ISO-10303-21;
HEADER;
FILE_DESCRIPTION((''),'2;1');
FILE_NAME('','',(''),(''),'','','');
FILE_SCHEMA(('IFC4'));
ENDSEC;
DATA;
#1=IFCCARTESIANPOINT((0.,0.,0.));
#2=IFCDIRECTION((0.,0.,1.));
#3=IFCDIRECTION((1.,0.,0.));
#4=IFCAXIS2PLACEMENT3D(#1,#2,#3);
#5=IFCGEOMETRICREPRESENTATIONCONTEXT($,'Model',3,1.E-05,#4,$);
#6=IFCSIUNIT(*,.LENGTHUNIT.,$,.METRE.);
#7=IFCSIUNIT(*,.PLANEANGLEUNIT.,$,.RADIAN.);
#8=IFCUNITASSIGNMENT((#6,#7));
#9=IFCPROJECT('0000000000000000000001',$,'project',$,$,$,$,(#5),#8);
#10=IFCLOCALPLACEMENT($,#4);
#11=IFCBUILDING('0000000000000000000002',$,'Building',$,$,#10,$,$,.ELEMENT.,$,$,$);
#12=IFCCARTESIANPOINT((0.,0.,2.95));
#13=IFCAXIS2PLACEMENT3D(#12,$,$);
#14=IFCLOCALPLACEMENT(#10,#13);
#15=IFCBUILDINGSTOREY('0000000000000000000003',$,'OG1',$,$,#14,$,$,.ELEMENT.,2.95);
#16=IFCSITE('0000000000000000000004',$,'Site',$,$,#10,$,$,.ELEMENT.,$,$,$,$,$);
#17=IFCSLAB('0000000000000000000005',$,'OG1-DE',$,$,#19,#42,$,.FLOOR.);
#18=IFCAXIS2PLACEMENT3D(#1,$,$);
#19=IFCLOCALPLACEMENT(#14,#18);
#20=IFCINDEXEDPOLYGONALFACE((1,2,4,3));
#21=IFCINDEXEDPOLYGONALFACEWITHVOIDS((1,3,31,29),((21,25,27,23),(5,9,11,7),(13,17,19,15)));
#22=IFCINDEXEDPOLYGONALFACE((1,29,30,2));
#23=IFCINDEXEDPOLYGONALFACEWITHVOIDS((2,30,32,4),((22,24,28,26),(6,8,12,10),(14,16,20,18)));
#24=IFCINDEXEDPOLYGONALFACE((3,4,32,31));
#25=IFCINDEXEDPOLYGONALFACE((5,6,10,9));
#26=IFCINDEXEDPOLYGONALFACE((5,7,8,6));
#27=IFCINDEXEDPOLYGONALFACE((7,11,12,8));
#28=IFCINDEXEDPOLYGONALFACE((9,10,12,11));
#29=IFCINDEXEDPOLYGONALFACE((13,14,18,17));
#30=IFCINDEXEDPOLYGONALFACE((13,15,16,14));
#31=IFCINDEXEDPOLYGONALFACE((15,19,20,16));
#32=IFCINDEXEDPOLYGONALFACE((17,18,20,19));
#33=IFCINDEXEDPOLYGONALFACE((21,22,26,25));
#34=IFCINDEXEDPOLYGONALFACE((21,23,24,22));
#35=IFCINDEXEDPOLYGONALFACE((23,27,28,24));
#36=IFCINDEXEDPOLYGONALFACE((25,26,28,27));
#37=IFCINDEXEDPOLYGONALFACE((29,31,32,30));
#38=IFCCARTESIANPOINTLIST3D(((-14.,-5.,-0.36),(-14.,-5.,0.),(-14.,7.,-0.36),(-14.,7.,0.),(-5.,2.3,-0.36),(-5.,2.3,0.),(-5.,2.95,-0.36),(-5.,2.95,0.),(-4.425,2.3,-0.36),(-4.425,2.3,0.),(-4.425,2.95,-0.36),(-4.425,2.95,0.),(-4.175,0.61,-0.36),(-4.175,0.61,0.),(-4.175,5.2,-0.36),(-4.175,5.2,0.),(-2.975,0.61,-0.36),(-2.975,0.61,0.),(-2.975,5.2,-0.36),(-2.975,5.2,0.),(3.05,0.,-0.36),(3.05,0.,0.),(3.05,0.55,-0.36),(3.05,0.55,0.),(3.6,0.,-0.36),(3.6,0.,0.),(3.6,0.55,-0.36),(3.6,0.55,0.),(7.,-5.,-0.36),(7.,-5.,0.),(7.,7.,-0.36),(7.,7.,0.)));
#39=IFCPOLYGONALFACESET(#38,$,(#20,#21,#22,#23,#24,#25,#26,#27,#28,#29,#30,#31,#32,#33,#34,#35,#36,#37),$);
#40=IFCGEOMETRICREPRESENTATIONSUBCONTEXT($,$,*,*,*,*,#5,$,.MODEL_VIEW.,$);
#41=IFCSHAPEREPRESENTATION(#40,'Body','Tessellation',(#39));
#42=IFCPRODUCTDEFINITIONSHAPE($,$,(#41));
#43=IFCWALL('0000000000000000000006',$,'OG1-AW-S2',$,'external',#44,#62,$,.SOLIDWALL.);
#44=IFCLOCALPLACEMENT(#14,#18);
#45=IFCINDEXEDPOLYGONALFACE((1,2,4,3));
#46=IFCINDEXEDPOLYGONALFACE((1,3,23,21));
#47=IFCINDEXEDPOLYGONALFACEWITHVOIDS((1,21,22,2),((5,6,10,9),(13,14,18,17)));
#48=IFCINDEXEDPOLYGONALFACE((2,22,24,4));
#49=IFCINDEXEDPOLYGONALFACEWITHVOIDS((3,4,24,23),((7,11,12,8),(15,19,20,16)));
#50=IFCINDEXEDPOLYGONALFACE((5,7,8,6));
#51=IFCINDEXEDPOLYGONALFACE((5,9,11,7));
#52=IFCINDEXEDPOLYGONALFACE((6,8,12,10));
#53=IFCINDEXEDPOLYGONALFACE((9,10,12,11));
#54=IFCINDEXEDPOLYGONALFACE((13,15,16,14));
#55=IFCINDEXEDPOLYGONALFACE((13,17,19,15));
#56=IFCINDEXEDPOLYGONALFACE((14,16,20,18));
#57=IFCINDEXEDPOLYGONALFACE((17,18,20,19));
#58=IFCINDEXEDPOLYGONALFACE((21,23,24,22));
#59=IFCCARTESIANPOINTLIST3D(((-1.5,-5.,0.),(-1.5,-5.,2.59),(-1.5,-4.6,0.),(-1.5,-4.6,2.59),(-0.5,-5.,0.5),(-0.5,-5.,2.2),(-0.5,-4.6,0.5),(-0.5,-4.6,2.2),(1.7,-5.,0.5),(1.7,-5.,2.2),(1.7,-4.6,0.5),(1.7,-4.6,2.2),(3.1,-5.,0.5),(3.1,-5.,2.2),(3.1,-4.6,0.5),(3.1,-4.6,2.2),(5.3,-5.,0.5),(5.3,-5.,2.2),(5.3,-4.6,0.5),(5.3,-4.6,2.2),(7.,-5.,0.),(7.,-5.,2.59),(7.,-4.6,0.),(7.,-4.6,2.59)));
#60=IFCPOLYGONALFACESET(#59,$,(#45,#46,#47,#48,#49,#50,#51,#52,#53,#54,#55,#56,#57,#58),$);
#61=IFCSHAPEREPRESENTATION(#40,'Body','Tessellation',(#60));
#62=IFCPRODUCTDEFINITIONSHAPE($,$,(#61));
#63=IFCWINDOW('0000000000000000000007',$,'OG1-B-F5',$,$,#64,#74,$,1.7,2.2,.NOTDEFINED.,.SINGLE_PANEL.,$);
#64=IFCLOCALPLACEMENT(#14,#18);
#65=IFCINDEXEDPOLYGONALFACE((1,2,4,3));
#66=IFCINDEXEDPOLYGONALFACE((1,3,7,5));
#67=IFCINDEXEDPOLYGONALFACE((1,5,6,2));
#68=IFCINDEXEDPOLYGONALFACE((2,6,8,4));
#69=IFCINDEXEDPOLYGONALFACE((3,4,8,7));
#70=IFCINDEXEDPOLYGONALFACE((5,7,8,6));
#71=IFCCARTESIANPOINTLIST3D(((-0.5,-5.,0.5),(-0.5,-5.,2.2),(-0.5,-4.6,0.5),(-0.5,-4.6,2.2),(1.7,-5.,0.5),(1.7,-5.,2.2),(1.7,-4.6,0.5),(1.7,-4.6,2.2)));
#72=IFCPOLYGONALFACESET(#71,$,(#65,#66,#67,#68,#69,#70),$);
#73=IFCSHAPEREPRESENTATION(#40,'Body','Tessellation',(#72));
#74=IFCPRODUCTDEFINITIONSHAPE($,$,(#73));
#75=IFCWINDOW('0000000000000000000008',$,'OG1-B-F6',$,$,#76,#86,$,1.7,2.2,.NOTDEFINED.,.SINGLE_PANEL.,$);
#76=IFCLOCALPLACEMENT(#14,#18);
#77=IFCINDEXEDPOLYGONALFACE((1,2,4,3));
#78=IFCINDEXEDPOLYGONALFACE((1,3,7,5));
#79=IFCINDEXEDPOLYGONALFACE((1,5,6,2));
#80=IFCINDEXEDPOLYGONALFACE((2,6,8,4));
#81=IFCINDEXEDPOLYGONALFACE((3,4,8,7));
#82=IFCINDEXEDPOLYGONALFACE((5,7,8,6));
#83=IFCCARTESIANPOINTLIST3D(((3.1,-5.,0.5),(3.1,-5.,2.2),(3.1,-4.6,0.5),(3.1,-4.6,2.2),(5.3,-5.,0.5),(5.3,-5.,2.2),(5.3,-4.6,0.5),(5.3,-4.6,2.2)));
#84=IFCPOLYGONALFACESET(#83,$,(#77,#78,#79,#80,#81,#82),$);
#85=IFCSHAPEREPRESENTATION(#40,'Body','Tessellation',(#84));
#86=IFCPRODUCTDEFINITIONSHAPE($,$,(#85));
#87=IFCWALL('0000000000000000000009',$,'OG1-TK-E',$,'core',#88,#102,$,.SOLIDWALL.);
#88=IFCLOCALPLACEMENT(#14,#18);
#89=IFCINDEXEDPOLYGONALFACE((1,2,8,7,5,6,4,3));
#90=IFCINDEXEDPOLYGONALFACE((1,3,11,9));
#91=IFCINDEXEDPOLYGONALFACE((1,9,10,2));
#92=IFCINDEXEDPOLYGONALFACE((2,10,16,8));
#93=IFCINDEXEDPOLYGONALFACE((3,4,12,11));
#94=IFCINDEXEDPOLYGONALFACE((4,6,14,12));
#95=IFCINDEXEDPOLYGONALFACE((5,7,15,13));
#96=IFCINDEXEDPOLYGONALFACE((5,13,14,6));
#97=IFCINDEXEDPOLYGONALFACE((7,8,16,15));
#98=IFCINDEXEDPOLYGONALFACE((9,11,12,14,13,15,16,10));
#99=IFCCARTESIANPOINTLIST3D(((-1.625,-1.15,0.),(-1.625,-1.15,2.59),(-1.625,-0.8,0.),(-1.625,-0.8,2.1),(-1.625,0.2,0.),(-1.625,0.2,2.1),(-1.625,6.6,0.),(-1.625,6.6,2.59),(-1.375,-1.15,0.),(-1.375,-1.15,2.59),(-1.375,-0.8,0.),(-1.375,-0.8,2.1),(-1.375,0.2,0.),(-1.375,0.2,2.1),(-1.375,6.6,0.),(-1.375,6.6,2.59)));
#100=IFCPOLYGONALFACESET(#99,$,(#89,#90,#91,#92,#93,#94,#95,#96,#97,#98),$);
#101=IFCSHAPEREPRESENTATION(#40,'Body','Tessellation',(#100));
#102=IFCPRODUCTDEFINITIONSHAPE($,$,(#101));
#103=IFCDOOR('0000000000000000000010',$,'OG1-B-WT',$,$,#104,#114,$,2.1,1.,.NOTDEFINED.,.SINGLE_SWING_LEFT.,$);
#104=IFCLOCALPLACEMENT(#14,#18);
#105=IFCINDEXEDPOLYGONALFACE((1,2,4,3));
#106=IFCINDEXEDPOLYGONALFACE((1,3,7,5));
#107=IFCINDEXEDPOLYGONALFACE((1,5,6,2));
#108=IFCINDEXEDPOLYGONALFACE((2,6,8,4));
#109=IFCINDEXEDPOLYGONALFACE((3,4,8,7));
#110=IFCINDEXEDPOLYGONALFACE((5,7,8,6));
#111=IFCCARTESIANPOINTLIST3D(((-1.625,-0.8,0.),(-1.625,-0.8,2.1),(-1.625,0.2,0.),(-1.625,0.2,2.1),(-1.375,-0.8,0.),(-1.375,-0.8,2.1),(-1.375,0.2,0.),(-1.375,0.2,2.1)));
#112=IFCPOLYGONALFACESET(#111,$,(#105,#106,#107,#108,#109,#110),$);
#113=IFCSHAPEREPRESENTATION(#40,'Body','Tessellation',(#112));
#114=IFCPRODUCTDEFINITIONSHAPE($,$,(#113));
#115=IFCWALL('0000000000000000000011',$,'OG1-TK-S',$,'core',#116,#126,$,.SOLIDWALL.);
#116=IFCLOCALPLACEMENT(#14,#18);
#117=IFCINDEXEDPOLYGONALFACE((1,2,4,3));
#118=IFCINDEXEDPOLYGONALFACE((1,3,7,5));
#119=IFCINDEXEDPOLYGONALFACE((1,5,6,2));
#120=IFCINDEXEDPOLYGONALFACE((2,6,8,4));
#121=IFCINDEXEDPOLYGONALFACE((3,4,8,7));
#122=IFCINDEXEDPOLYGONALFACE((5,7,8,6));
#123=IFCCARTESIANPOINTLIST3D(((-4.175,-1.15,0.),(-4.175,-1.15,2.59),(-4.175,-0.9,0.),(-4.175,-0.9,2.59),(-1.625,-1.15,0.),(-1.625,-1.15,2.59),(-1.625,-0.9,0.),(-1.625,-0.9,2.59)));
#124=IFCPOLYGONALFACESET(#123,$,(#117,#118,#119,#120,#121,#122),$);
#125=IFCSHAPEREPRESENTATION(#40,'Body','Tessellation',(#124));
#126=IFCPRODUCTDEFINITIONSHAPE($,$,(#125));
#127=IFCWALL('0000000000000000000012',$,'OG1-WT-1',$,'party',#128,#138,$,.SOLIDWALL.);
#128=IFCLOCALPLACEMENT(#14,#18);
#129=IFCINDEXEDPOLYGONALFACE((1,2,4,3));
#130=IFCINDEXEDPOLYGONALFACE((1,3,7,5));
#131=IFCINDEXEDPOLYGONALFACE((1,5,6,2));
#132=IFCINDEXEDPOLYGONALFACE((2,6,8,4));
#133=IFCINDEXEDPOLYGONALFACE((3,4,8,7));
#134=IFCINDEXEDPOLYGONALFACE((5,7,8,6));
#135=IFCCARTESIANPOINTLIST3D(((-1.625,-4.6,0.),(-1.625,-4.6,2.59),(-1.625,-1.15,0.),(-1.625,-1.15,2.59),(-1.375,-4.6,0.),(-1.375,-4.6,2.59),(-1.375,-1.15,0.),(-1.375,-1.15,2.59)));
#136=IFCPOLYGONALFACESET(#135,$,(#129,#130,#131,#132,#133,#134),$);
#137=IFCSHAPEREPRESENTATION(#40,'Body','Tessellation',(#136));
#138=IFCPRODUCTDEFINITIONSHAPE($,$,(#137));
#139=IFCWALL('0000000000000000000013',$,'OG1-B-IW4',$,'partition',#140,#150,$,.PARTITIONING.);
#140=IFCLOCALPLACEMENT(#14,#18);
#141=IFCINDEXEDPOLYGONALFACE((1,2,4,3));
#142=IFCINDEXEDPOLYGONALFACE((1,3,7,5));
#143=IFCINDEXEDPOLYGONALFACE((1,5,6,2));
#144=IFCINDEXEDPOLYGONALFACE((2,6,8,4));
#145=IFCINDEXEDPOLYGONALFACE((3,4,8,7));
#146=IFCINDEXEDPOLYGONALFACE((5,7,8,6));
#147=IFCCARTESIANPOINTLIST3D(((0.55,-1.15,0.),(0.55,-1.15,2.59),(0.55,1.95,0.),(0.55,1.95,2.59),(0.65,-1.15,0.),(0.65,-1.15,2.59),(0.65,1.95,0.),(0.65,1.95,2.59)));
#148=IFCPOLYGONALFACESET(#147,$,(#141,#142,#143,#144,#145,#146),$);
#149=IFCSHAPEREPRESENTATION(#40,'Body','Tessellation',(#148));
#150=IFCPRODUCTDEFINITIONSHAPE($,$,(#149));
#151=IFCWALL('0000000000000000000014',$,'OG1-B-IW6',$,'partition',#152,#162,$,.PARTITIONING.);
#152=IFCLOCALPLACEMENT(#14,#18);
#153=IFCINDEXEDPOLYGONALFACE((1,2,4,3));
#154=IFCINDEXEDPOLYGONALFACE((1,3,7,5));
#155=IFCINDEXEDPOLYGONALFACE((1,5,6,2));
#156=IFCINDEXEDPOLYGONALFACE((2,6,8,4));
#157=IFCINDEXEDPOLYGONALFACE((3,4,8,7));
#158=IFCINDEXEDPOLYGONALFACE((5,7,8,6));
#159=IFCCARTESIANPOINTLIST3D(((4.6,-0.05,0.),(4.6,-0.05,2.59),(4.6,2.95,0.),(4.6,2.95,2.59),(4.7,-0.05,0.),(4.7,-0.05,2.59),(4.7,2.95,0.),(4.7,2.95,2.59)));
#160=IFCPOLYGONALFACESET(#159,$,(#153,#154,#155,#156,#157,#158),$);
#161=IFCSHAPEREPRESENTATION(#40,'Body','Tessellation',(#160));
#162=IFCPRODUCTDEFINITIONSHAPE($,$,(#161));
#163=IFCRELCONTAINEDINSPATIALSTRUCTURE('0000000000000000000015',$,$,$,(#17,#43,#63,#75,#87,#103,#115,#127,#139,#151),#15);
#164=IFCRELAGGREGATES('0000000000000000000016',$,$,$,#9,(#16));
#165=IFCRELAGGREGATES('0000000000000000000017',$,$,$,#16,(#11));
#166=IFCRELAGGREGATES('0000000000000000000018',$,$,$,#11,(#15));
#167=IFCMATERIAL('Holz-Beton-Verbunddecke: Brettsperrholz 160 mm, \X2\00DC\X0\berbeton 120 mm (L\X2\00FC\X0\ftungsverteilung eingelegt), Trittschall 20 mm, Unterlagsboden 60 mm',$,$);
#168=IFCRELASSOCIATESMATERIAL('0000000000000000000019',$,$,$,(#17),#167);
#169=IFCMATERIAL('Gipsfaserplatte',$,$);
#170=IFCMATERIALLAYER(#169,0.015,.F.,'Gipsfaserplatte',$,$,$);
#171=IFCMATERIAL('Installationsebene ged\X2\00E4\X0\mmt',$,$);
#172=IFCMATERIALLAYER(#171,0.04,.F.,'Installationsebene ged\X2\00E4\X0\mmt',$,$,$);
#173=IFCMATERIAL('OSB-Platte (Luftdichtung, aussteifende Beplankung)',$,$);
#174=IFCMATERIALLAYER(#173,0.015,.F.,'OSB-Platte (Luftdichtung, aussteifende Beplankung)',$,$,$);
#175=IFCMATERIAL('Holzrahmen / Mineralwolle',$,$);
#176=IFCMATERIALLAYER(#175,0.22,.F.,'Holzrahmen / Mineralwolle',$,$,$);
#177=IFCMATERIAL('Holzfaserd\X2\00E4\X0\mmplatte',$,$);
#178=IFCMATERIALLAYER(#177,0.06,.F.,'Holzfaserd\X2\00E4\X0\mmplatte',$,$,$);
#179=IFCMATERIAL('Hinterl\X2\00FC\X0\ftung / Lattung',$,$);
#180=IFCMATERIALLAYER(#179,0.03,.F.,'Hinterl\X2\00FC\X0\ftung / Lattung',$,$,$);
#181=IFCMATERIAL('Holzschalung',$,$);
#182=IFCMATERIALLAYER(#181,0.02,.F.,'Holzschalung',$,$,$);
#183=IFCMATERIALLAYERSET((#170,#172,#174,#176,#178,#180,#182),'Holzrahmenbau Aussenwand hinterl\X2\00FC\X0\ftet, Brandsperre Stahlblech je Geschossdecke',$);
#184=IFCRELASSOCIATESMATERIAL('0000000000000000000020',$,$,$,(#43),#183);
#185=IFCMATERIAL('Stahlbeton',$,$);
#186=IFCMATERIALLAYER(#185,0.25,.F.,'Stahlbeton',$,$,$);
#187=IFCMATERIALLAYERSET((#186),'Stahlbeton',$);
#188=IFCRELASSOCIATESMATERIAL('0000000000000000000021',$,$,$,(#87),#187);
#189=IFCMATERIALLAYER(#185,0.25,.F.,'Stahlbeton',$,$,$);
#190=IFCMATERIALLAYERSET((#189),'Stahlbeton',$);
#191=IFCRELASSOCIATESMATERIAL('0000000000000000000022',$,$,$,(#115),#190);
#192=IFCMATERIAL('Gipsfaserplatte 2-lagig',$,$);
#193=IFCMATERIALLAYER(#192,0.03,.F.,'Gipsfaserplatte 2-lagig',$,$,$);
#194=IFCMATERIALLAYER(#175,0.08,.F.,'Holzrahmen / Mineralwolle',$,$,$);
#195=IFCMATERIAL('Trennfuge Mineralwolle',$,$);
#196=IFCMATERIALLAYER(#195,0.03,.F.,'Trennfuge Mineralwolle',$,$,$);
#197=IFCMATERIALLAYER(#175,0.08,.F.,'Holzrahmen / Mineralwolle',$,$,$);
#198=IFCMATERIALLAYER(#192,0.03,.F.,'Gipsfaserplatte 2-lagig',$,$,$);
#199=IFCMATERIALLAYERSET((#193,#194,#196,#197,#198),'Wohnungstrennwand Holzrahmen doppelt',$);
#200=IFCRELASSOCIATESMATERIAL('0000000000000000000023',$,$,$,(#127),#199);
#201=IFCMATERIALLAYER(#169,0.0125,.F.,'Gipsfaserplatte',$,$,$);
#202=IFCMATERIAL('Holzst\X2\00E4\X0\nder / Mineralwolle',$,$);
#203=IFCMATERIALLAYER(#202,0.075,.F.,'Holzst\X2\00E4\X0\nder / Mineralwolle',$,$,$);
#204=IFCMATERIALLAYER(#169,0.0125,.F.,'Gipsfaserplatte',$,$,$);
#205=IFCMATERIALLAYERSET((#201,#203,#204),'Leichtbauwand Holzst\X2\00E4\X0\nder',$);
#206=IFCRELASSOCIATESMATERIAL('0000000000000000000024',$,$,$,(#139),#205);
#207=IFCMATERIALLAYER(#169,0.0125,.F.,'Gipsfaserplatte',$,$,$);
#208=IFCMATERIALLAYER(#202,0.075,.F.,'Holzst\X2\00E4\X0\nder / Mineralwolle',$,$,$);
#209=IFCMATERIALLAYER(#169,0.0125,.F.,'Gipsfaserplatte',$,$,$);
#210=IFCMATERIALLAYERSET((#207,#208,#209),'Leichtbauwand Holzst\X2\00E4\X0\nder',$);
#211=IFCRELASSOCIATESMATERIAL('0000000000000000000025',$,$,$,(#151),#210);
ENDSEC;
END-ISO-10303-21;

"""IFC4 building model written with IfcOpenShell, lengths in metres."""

from ifc_helpers import new_model, si_unit, frame, frame_2d, origin, origin_with_axes, origin_2d, place, context, subcontext, project, spatial, polyline, rectangle, outline, extrude, material, layer, layer_set, element, fill, save


model = new_model("IFC4")

# Units and contexts
model_context = context("Model", 3, precision=1e-05, world=origin_with_axes())
sub_context = subcontext(model_context, None, None, "MODEL_VIEW")
ifc_project = project(units=[si_unit("LENGTHUNIT", "METRE"), si_unit("PLANEANGLEUNIT", "RADIAN")], contexts=[model_context])

# Site, building, storey
placement = place(None, origin_with_axes())
site = spatial("IfcSite", under=ifc_project, at=placement, Name="Site", CompositionType="ELEMENT")
building = spatial("IfcBuilding", under=site, at=placement, Name="Building", CompositionType="ELEMENT")
storey_placement = place(placement, frame((0.0, 0.0, 2.95)))
storey = spatial("IfcBuildingStorey", under=building, at=storey_placement, Name="OG1", CompositionType="ELEMENT", Elevation=2.95)

# Slab, openings
ifc_material_1 = material(Name="Holz-Beton-Verbunddecke: Brettsperrholz 160 mm, Überbeton 120 mm (Lüftungsverteilung eingelegt), Trittschall 20 mm, Unterlagsboden 60 mm")
slab_placement = place(storey_placement, frame((0.0, 0.0, -0.36)))
slab = element("IfcSlab", 1, at=slab_placement, inside=storey, material=ifc_material_1, Name="OG1-DE", PredefinedType="FLOOR", context=sub_context, shape_type="SweptSolid", body=[
    extrude(outline(polyline([(-14.0, -5.0), (7.0, -5.0), (7.0, 7.0), (-14.0, 7.0), (-14.0, -5.0)])), origin(), (0.0, 0.0, 1.0), 0.36),
])
opening_1_placement = place(slab_placement, frame((-3.575, 2.905, 0.0)))
element("IfcOpeningElement", 2, at=opening_1_placement, cuts=slab, PredefinedType="OPENING", context=sub_context, shape_type="SweptSolid", body=[
    extrude(rectangle(XDim=1.2, YDim=4.59, at=origin_2d()), origin(), (0.0, 0.0, 1.0), 0.46),
])
opening_2_placement = place(slab_placement, frame((-4.7125, 2.625, 0.0)))
element("IfcOpeningElement", 3, at=opening_2_placement, cuts=slab, PredefinedType="OPENING", context=sub_context, shape_type="SweptSolid", body=[
    extrude(rectangle(XDim=0.575, YDim=0.65, at=origin_2d()), origin(), (0.0, 0.0, 1.0), 0.46),
])
opening_3_placement = place(slab_placement, frame((3.325, 0.275, 0.0)))
element("IfcOpeningElement", 4, at=opening_3_placement, cuts=slab, PredefinedType="OPENING", context=sub_context, shape_type="SweptSolid", body=[
    extrude(rectangle(XDim=0.55, YDim=0.55, at=origin_2d()), origin(), (0.0, 0.0, 1.0), 0.46),
])

# Wall, openings, windows
ifc_material_2 = material(Name="Gipsfaserplatte")
ifc_layer_1 = layer(ifc_material_2, 0.015, ventilated=False, Name="Gipsfaserplatte")
ifc_material_3 = material(Name="Installationsebene gedämmt")
ifc_layer_2 = layer(ifc_material_3, 0.04, ventilated=False, Name="Installationsebene gedämmt")
ifc_material_4 = material(Name="OSB-Platte (Luftdichtung, aussteifende Beplankung)")
ifc_layer_3 = layer(ifc_material_4, 0.015, ventilated=False, Name="OSB-Platte (Luftdichtung, aussteifende Beplankung)")
ifc_material_5 = material(Name="Holzrahmen / Mineralwolle")
ifc_layer_4 = layer(ifc_material_5, 0.22, ventilated=False, Name="Holzrahmen / Mineralwolle")
ifc_material_6 = material(Name="Holzfaserdämmplatte")
ifc_layer_5 = layer(ifc_material_6, 0.06, ventilated=False, Name="Holzfaserdämmplatte")
ifc_material_7 = material(Name="Hinterlüftung / Lattung")
ifc_layer_6 = layer(ifc_material_7, 0.03, ventilated=False, Name="Hinterlüftung / Lattung")
ifc_material_8 = material(Name="Holzschalung")
ifc_layer_7 = layer(ifc_material_8, 0.02, ventilated=False, Name="Holzschalung")
ifc_layer_set_1 = layer_set([ifc_layer_1, ifc_layer_2, ifc_layer_3, ifc_layer_4, ifc_layer_5, ifc_layer_6, ifc_layer_7], Name="Holzrahmenbau Aussenwand hinterlüftet, Brandsperre Stahlblech je Geschossdecke")
wall_1_placement = place(storey_placement, frame((7.0, -4.8, 0.0), z_axis=(0.0, 0.0, 1.0), x_axis=(-1.0, 0.0, 0.0)))
wall_1 = element("IfcWall", 5, at=wall_1_placement, inside=storey, material=ifc_layer_set_1, Name="OG1-AW-S2", ObjectType="external", PredefinedType="SOLIDWALL", context=sub_context, shape_type="SweptSolid", body=[
    extrude(rectangle(XDim=8.5, YDim=0.4, at=frame_2d((4.25, 0.0))), origin(), (0.0, 0.0, 1.0), 2.59),
])
opening_4_placement = place(wall_1_placement, frame((6.4, 0.25, 0.5), z_axis=(0.0, -1.0, 0.0), x_axis=(1.0, 0.0, 0.0)))
opening_4 = element("IfcOpeningElement", 6, at=opening_4_placement, cuts=wall_1, PredefinedType="OPENING", context=sub_context, shape_type="SweptSolid", body=[
    extrude(rectangle(XDim=2.2, YDim=1.7, at=frame_2d((0.0, 0.85))), origin(), (0.0, 0.0, 1.0), 0.5),
])
opening_5_placement = place(wall_1_placement, frame((2.8, 0.25, 0.5), z_axis=(0.0, -1.0, 0.0), x_axis=(1.0, 0.0, 0.0)))
opening_5 = element("IfcOpeningElement", 7, at=opening_5_placement, cuts=wall_1, PredefinedType="OPENING", context=sub_context, shape_type="SweptSolid", body=[
    extrude(rectangle(XDim=2.2, YDim=1.7, at=frame_2d((0.0, 0.85))), origin(), (0.0, 0.0, 1.0), 0.5),
])
window_1_placement = place(wall_1_placement, frame((6.4, 0.2, 0.5), z_axis=(0.0, -1.0, 0.0), x_axis=(1.0, 0.0, 0.0)))
window_1 = element("IfcWindow", 8, at=window_1_placement, inside=storey, Name="OG1-B-F5", OverallHeight=1.7, OverallWidth=2.2, PartitioningType="SINGLE_PANEL", PredefinedType="NOTDEFINED", context=sub_context, shape_type="SweptSolid", body=[
    extrude(rectangle(XDim=2.2, YDim=1.7, at=frame_2d((0.0, 0.85))), origin(), (0.0, 0.0, 1.0), 0.4),
])
fill(opening_4, window_1)
window_2_placement = place(wall_1_placement, frame((2.8, 0.2, 0.5), z_axis=(0.0, -1.0, 0.0), x_axis=(1.0, 0.0, 0.0)))
window_2 = element("IfcWindow", 9, at=window_2_placement, inside=storey, Name="OG1-B-F6", OverallHeight=1.7, OverallWidth=2.2, PartitioningType="SINGLE_PANEL", PredefinedType="NOTDEFINED", context=sub_context, shape_type="SweptSolid", body=[
    extrude(rectangle(XDim=2.2, YDim=1.7, at=frame_2d((0.0, 0.85))), origin(), (0.0, 0.0, 1.0), 0.4),
])
fill(opening_5, window_2)

# Wall, opening, door
ifc_material_9 = material(Name="Stahlbeton")
ifc_layer_8 = layer(ifc_material_9, 0.25, ventilated=False, Name="Stahlbeton")
ifc_layer_set_2 = layer_set([ifc_layer_8], Name="Stahlbeton")
wall_2_placement = place(storey_placement, frame((-1.5, -1.15, 0.0), z_axis=(0.0, 0.0, 1.0), x_axis=(0.0, 1.0, 0.0)))
wall_2 = element("IfcWall", 10, at=wall_2_placement, inside=storey, material=ifc_layer_set_2, Name="OG1-TK-E", ObjectType="core", PredefinedType="SOLIDWALL", context=sub_context, shape_type="SweptSolid", body=[
    extrude(rectangle(XDim=7.75, YDim=0.25, at=frame_2d((3.875, 0.0))), origin(), (0.0, 0.0, 1.0), 2.59),
])
opening_6_placement = place(wall_2_placement, frame((0.85, 0.175, 0.0), z_axis=(0.0, -1.0, 0.0), x_axis=(1.0, 0.0, 0.0)))
opening_6 = element("IfcOpeningElement", 11, at=opening_6_placement, cuts=wall_2, PredefinedType="OPENING", context=sub_context, shape_type="SweptSolid", body=[
    extrude(rectangle(XDim=1.0, YDim=2.1, at=frame_2d((0.0, 1.05))), origin(), (0.0, 0.0, 1.0), 0.35),
])
door_1_placement = place(wall_2_placement, frame((0.85, 0.125, 0.0), z_axis=(0.0, -1.0, 0.0), x_axis=(1.0, 0.0, 0.0)))
door_1 = element("IfcDoor", 12, at=door_1_placement, inside=storey, Name="OG1-B-WT", OperationType="SINGLE_SWING_LEFT", OverallHeight=2.1, OverallWidth=1.0, PredefinedType="NOTDEFINED", context=sub_context, shape_type="SweptSolid", body=[
    extrude(rectangle(XDim=1.0, YDim=2.1, at=frame_2d((0.0, 1.05))), origin(), (0.0, 0.0, 1.0), 0.25),
])
fill(opening_6, door_1)

# Walls
ifc_layer_9 = layer(ifc_material_9, 0.25, ventilated=False, Name="Stahlbeton")
ifc_layer_set_3 = layer_set([ifc_layer_9], Name="Stahlbeton")
wall_3_placement = place(storey_placement, frame((-4.175, -1.025, 0.0), z_axis=(0.0, 0.0, 1.0), x_axis=(1.0, 0.0, 0.0)))
element("IfcWall", 13, at=wall_3_placement, inside=storey, material=ifc_layer_set_3, Name="OG1-TK-S", ObjectType="core", PredefinedType="SOLIDWALL", context=sub_context, shape_type="SweptSolid", body=[
    extrude(rectangle(XDim=2.55, YDim=0.25, at=frame_2d((1.275, 0.0))), origin(), (0.0, 0.0, 1.0), 2.59),
])
ifc_material_10 = material(Name="Gipsfaserplatte 2-lagig")
ifc_layer_10 = layer(ifc_material_10, 0.03, ventilated=False, Name="Gipsfaserplatte 2-lagig")
ifc_layer_11 = layer(ifc_material_5, 0.08, ventilated=False, Name="Holzrahmen / Mineralwolle")
ifc_material_11 = material(Name="Trennfuge Mineralwolle")
ifc_layer_12 = layer(ifc_material_11, 0.03, ventilated=False, Name="Trennfuge Mineralwolle")
ifc_layer_13 = layer(ifc_material_5, 0.08, ventilated=False, Name="Holzrahmen / Mineralwolle")
ifc_layer_14 = layer(ifc_material_10, 0.03, ventilated=False, Name="Gipsfaserplatte 2-lagig")
ifc_layer_set_4 = layer_set([ifc_layer_10, ifc_layer_11, ifc_layer_12, ifc_layer_13, ifc_layer_14], Name="Wohnungstrennwand Holzrahmen doppelt")
wall_4_placement = place(storey_placement, frame((-1.5, -1.15, 0.0), z_axis=(0.0, 0.0, 1.0), x_axis=(0.0, -1.0, 0.0)))
element("IfcWall", 14, at=wall_4_placement, inside=storey, material=ifc_layer_set_4, Name="OG1-WT-1", ObjectType="party", PredefinedType="SOLIDWALL", context=sub_context, shape_type="SweptSolid", body=[
    extrude(rectangle(XDim=3.45, YDim=0.25, at=frame_2d((1.725, 0.0))), origin(), (0.0, 0.0, 1.0), 2.59),
])
ifc_layer_15 = layer(ifc_material_2, 0.0125, ventilated=False, Name="Gipsfaserplatte")
ifc_material_12 = material(Name="Holzständer / Mineralwolle")
ifc_layer_16 = layer(ifc_material_12, 0.075, ventilated=False, Name="Holzständer / Mineralwolle")
ifc_layer_17 = layer(ifc_material_2, 0.0125, ventilated=False, Name="Gipsfaserplatte")
ifc_layer_set_5 = layer_set([ifc_layer_15, ifc_layer_16, ifc_layer_17], Name="Leichtbauwand Holzständer")
wall_5_placement = place(storey_placement, frame((0.6, -1.15, 0.0), z_axis=(0.0, 0.0, 1.0), x_axis=(0.0, 1.0, 0.0)))
element("IfcWall", 15, at=wall_5_placement, inside=storey, material=ifc_layer_set_5, Name="OG1-B-IW4", ObjectType="partition", PredefinedType="PARTITIONING", context=sub_context, shape_type="SweptSolid", body=[
    extrude(rectangle(XDim=3.1, YDim=0.1, at=frame_2d((1.55, 0.0))), origin(), (0.0, 0.0, 1.0), 2.59),
])
ifc_layer_18 = layer(ifc_material_2, 0.0125, ventilated=False, Name="Gipsfaserplatte")
ifc_layer_19 = layer(ifc_material_12, 0.075, ventilated=False, Name="Holzständer / Mineralwolle")
ifc_layer_20 = layer(ifc_material_2, 0.0125, ventilated=False, Name="Gipsfaserplatte")
ifc_layer_set_6 = layer_set([ifc_layer_18, ifc_layer_19, ifc_layer_20], Name="Leichtbauwand Holzständer")
wall_6_placement = place(storey_placement, frame((4.65, -0.05, 0.0), z_axis=(0.0, 0.0, 1.0), x_axis=(0.0, 1.0, 0.0)))
element("IfcWall", 16, at=wall_6_placement, inside=storey, material=ifc_layer_set_6, Name="OG1-B-IW6", ObjectType="partition", PredefinedType="PARTITIONING", context=sub_context, shape_type="SweptSolid", body=[
    extrude(rectangle(XDim=3.0, YDim=0.1, at=frame_2d((1.5, 0.0))), origin(), (0.0, 0.0, 1.0), 2.59),
])

save(model, "model.ifc")
